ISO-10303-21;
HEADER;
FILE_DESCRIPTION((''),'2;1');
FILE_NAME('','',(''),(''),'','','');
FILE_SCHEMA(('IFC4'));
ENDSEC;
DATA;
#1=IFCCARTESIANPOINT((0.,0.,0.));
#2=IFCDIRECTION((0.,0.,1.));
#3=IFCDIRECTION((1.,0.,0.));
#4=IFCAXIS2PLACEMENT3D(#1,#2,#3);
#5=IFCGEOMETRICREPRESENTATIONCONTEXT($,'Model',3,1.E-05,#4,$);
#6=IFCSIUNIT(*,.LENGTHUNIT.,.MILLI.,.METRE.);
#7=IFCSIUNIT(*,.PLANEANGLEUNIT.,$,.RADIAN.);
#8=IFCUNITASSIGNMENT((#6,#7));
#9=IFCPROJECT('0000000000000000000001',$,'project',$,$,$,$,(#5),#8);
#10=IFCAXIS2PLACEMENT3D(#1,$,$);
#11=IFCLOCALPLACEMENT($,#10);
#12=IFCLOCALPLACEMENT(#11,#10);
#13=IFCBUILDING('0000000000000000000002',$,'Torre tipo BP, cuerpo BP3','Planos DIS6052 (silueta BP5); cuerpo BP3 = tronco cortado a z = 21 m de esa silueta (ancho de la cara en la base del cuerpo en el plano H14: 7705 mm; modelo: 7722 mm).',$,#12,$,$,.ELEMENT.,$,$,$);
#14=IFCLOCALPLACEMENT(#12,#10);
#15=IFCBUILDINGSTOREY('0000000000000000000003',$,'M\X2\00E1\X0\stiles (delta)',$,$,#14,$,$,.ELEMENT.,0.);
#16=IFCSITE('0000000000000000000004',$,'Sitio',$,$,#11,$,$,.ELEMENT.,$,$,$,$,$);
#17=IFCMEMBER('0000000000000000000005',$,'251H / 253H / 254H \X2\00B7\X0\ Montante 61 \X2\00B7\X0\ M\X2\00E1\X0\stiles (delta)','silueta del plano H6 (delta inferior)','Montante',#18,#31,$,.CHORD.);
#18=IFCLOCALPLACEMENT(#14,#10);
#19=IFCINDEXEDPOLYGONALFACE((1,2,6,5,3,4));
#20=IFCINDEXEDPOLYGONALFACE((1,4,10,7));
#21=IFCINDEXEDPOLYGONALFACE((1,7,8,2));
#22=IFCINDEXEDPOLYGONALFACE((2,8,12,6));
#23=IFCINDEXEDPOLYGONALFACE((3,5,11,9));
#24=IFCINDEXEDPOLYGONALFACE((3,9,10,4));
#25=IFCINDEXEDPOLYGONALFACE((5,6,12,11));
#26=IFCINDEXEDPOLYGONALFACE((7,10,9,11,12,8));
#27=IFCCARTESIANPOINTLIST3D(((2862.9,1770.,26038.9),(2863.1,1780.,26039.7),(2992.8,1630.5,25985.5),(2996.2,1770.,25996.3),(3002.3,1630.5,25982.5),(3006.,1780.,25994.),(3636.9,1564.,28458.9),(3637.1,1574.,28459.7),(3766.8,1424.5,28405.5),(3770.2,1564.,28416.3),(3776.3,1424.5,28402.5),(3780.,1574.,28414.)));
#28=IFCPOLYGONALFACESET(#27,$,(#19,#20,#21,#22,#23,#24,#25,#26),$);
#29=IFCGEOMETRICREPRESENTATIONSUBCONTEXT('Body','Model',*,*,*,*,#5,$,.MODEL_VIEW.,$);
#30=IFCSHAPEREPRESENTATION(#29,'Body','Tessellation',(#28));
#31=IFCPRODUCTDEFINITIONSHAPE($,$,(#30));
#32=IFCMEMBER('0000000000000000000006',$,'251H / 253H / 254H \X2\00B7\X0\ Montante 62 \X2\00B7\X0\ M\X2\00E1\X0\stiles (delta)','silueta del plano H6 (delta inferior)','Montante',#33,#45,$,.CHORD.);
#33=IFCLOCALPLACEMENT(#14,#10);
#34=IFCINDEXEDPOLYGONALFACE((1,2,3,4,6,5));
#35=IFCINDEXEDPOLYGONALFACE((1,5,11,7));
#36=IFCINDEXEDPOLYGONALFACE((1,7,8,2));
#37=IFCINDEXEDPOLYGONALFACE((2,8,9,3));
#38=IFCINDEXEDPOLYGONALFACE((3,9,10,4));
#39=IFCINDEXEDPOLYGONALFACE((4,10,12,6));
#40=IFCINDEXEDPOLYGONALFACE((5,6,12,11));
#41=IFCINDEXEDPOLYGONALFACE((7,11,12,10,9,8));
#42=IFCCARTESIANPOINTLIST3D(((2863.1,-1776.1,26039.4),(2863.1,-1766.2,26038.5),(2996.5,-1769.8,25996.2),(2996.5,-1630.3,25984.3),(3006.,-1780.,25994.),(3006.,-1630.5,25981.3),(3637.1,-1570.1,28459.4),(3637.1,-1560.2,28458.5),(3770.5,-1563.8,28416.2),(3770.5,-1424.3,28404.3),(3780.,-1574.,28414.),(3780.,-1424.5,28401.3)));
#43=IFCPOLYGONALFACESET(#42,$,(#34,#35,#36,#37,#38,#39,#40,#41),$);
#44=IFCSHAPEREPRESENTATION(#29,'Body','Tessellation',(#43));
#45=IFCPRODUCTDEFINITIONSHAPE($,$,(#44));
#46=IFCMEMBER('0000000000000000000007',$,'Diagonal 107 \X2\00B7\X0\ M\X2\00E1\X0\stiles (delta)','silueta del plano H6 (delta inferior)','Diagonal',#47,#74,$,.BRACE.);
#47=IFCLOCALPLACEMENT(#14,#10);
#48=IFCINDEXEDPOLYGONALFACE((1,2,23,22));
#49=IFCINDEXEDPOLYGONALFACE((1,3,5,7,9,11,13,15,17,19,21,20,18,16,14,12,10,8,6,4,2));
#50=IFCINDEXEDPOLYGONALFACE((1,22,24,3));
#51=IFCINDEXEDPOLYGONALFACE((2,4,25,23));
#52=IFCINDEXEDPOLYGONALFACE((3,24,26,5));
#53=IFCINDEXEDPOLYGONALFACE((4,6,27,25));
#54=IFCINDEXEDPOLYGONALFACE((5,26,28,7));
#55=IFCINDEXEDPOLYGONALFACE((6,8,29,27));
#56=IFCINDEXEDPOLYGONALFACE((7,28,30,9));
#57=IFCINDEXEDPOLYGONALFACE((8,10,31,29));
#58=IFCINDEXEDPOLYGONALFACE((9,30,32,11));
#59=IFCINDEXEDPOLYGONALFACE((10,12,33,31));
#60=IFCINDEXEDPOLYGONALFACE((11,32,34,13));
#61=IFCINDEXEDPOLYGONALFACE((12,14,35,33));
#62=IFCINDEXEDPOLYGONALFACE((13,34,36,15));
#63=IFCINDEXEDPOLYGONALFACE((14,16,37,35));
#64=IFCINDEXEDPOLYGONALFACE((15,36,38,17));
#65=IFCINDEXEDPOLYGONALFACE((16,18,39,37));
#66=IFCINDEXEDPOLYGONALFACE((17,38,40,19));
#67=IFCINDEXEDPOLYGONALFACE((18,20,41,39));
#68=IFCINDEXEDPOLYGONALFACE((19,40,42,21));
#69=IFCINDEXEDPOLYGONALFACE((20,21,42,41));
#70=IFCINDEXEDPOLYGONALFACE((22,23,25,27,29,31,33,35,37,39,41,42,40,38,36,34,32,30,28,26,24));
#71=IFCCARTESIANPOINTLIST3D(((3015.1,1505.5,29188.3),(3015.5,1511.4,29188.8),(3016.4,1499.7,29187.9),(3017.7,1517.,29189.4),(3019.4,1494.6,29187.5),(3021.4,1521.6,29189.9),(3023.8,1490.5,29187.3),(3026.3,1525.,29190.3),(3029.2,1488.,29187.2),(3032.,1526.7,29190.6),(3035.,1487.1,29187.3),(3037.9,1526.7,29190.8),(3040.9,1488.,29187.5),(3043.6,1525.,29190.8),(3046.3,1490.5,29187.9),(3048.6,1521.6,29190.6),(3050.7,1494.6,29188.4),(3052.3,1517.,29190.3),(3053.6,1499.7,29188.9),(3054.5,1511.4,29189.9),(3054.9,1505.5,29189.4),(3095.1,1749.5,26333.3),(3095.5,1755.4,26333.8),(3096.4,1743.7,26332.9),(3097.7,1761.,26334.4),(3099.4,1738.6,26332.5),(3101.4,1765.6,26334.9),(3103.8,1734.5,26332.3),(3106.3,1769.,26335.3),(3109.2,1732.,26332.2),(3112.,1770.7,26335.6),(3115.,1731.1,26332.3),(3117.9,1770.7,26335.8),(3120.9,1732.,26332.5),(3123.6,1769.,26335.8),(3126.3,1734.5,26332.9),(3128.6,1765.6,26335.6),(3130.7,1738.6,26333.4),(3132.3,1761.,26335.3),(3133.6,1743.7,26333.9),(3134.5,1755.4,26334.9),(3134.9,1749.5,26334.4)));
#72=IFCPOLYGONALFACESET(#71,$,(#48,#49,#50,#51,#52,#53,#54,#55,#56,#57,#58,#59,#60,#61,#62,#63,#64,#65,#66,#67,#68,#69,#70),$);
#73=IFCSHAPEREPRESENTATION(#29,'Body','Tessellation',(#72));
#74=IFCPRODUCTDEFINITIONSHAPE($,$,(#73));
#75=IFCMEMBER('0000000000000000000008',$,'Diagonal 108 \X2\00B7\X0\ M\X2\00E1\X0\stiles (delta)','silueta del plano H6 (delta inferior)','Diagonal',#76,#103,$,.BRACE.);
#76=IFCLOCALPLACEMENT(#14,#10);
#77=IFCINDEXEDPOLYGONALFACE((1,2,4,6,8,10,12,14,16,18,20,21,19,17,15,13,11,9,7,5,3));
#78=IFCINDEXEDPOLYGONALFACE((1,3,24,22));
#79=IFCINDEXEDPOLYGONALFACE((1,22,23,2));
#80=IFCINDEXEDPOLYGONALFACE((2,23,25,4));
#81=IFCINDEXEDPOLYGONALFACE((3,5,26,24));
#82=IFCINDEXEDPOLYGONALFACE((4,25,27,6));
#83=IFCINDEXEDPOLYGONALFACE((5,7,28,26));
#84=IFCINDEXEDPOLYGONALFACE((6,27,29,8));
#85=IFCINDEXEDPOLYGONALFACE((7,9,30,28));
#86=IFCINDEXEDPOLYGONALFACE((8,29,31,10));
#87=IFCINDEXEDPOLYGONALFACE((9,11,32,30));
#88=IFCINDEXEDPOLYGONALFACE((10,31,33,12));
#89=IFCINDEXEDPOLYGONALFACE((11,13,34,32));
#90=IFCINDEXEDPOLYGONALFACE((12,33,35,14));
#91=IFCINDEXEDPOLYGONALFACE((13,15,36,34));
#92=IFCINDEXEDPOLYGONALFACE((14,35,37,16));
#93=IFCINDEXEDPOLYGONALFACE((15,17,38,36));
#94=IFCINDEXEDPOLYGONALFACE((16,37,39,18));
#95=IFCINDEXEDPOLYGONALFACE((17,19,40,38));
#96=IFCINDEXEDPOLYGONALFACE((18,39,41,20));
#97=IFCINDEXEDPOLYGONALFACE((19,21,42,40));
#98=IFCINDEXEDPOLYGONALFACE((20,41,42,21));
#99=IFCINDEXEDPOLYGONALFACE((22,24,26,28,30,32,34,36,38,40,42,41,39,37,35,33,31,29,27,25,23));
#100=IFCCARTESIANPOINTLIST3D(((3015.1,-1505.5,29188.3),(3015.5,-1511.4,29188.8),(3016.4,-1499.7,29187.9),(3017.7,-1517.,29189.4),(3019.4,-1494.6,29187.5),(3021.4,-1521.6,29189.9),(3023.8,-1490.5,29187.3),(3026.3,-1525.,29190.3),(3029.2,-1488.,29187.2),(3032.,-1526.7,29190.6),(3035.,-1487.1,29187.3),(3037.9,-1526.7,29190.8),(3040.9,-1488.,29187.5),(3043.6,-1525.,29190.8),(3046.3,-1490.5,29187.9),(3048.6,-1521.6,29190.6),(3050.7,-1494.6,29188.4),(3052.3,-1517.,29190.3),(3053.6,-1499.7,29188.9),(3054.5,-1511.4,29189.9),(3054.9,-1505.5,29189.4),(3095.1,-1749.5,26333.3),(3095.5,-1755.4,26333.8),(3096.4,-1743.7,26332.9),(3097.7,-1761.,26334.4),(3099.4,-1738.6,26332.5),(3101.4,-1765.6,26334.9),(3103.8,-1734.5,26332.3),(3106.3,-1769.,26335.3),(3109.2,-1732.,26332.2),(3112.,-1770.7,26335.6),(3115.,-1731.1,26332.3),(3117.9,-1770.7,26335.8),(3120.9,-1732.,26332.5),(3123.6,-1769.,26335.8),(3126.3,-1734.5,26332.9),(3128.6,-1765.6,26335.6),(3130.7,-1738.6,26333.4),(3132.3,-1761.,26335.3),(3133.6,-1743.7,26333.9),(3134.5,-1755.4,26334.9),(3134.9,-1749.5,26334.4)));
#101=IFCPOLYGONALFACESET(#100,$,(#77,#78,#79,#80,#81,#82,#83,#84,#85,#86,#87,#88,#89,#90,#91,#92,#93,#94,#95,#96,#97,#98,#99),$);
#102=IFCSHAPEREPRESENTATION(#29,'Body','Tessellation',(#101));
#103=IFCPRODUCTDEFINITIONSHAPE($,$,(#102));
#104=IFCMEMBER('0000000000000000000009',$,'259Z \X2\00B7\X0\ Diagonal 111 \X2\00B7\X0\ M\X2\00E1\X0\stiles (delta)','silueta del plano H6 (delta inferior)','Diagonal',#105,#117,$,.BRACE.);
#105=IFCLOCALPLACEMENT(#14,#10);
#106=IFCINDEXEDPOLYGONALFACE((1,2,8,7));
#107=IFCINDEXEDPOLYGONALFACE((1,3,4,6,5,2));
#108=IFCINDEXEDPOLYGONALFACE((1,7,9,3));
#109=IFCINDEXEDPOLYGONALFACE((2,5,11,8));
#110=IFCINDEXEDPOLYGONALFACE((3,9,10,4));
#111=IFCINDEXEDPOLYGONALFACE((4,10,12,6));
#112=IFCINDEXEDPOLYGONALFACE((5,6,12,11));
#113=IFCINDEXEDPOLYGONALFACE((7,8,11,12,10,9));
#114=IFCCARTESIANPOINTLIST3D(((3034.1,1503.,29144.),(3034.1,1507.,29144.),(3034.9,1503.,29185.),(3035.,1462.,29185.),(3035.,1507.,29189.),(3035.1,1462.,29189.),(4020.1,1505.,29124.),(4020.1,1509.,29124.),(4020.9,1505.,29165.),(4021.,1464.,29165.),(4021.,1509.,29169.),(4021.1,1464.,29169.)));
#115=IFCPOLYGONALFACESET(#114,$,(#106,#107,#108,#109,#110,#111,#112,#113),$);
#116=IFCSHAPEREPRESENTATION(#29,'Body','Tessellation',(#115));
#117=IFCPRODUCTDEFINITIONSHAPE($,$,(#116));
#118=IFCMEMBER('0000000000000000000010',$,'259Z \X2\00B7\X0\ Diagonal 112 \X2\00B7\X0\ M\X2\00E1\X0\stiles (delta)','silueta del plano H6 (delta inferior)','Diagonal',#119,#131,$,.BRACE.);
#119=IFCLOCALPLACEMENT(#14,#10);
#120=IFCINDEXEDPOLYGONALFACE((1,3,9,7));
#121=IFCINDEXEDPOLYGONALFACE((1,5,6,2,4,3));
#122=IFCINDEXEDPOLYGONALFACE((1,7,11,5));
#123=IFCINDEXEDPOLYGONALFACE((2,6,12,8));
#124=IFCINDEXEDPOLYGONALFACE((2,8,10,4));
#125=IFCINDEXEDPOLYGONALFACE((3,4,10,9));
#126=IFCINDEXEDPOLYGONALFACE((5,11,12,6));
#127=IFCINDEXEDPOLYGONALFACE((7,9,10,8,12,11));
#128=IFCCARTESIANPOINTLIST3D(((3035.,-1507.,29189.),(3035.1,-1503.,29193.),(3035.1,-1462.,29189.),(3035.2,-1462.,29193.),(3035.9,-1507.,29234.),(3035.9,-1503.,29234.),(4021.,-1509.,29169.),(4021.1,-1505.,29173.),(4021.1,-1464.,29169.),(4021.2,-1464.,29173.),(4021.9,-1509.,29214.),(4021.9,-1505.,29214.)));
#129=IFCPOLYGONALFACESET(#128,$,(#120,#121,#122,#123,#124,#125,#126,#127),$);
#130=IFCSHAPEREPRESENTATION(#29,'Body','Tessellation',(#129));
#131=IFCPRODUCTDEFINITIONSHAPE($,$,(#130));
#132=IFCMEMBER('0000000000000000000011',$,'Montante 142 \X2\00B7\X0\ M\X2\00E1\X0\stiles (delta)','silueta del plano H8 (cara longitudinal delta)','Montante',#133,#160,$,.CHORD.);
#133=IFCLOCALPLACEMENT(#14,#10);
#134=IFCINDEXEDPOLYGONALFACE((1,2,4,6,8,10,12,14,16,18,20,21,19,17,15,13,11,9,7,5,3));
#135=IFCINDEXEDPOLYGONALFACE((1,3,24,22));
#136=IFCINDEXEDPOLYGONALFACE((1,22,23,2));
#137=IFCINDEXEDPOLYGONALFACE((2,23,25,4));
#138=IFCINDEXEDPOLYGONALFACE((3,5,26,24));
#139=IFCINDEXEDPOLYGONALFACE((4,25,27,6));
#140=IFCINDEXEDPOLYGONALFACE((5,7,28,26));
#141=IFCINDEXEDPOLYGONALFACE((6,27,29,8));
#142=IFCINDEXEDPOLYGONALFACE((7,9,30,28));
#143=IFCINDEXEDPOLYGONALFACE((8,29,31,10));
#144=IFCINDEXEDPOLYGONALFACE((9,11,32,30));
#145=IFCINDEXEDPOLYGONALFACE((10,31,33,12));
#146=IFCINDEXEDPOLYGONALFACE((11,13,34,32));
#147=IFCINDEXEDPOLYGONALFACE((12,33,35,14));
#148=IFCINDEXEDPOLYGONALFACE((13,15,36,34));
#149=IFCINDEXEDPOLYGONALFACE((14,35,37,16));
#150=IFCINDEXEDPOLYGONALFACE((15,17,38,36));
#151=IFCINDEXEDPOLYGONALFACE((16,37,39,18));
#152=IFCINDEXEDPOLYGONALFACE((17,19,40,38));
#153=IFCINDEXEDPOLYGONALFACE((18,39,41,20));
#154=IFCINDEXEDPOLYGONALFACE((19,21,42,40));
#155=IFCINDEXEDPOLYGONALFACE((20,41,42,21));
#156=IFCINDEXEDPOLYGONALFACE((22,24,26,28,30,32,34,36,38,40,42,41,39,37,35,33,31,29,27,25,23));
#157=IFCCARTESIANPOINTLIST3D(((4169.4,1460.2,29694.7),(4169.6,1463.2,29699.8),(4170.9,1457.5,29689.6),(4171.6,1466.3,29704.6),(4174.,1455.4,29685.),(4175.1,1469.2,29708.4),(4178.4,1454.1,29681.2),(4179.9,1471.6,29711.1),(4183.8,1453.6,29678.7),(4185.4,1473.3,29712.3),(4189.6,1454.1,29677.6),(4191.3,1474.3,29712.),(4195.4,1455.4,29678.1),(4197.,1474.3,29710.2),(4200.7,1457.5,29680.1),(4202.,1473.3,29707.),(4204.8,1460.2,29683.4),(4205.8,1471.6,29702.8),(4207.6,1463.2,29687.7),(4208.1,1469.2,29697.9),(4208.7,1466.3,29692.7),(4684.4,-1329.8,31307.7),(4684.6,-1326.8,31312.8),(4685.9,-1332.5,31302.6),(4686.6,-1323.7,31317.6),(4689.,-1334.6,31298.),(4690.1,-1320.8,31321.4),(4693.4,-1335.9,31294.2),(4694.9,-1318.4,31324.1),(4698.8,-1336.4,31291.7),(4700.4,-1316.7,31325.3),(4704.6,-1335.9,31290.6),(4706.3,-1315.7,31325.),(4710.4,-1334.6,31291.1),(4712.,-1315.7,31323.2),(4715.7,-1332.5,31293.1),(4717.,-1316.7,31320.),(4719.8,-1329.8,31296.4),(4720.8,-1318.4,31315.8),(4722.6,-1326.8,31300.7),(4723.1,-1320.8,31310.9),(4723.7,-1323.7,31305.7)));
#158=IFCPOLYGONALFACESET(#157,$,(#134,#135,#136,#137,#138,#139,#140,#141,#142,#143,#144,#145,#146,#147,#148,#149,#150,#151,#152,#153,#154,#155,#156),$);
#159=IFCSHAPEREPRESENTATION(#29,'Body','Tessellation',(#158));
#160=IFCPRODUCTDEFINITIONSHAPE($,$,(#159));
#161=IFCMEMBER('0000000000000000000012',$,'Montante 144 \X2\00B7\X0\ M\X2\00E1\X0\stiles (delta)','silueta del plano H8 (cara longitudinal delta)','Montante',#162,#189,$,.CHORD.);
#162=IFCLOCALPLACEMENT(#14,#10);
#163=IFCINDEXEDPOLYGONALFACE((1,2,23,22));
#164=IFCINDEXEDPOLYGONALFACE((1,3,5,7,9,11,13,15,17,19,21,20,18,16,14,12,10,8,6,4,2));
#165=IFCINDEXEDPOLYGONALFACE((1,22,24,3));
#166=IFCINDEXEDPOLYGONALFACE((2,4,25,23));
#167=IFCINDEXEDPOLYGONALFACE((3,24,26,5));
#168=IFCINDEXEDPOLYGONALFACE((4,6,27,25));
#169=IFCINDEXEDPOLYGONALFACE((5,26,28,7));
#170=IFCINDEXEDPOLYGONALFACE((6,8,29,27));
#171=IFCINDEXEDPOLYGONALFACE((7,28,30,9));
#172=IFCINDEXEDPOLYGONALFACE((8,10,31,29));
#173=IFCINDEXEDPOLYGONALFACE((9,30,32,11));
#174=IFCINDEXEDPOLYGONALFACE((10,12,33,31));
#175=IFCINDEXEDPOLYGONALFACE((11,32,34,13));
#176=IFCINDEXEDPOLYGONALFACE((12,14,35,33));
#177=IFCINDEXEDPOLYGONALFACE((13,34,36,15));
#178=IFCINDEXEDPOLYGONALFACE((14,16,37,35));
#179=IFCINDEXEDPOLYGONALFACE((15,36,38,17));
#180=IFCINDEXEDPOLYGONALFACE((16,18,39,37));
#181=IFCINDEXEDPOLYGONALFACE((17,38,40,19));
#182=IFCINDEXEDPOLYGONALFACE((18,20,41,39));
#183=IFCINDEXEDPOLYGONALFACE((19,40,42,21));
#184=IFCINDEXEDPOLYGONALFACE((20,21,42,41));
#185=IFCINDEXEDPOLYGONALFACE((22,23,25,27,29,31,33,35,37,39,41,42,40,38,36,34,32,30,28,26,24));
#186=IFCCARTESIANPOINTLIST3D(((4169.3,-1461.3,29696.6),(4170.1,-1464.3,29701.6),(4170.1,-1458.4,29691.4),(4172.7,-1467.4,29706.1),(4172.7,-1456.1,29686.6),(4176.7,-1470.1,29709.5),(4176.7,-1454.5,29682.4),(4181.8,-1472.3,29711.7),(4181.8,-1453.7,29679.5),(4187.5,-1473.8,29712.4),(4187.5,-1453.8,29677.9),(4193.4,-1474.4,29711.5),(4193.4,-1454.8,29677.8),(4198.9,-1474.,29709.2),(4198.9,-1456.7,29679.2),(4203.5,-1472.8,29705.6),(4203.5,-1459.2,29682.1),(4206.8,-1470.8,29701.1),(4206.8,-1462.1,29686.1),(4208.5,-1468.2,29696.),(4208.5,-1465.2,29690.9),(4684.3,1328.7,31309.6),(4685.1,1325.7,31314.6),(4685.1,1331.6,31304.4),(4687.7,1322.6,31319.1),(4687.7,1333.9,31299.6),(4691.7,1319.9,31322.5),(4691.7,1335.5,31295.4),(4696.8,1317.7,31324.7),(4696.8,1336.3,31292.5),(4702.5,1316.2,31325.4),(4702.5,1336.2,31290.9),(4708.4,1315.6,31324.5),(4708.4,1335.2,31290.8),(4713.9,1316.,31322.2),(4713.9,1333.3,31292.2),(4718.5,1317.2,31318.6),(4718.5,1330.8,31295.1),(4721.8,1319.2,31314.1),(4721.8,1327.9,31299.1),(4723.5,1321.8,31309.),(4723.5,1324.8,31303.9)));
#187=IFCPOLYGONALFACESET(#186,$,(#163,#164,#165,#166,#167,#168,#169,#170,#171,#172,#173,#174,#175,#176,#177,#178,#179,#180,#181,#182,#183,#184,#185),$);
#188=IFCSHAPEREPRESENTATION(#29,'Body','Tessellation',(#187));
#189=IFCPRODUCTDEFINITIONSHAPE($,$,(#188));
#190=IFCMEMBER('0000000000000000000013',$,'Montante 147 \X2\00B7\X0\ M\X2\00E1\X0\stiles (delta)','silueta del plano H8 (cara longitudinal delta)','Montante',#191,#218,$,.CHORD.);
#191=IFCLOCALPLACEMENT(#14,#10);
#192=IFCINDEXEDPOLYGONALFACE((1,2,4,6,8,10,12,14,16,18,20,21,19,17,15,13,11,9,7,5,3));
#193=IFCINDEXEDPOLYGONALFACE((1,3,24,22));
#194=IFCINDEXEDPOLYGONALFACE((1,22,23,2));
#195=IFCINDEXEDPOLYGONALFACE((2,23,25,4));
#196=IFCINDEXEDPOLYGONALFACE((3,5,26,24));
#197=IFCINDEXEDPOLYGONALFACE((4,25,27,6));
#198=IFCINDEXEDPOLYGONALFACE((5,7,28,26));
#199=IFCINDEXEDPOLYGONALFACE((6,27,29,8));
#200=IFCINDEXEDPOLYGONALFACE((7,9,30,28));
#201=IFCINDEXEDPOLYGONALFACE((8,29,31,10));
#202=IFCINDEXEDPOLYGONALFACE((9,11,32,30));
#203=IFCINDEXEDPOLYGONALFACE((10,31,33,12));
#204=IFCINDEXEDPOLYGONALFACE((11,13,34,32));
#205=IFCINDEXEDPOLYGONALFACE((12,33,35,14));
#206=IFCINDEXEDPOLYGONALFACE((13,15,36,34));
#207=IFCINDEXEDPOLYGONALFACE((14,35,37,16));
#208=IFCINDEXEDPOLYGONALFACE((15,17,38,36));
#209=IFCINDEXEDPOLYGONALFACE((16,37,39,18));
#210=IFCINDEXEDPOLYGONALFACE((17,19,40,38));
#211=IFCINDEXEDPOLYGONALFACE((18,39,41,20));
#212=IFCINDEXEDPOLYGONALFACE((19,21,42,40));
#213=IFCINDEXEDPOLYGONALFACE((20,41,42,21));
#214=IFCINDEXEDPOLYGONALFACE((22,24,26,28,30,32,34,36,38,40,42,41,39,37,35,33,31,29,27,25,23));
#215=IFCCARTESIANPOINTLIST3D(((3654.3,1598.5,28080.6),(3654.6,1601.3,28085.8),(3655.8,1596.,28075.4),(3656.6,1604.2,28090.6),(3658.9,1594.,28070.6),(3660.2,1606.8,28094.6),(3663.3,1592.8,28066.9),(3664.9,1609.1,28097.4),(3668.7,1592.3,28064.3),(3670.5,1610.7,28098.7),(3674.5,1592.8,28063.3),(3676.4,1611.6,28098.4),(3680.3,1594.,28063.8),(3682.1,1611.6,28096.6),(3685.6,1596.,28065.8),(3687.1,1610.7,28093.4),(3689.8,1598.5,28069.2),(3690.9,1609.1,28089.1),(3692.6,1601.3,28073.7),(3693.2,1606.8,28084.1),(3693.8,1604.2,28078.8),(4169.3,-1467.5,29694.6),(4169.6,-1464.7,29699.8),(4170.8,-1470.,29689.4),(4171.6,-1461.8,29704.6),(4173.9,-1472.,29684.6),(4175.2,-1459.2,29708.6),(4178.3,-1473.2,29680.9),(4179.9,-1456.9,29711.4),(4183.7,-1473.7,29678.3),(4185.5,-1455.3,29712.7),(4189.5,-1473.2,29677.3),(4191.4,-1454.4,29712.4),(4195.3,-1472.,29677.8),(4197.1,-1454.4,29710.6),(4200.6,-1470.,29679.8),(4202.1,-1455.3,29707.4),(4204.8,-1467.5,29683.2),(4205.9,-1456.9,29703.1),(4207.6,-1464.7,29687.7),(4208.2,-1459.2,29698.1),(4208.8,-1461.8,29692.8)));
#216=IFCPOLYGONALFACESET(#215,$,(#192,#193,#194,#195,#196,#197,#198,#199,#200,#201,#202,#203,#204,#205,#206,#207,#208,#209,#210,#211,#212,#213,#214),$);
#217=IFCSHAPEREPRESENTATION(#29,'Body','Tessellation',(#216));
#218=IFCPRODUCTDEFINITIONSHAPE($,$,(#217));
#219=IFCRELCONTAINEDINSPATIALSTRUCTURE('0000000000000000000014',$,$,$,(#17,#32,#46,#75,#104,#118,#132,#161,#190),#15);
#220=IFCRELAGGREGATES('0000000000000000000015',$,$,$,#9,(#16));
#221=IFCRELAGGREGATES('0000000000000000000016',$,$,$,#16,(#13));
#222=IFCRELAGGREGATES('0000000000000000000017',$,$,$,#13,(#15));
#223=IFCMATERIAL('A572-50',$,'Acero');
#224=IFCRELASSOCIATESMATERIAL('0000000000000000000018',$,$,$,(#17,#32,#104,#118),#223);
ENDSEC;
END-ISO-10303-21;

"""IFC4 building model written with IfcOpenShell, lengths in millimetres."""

from ifc_helpers import new_model, si_unit, frame, frame_2d, origin, origin_with_axes, place, context, subcontext, project, spatial, circle, l_section, extrude, material, element, save


model = new_model("IFC4")

# Units and contexts
model_context = context("Model", 3, precision=1e-05, world=origin_with_axes())
body_context = subcontext(model_context, "Body", "Model", "MODEL_VIEW")
ifc_project = project(units=[si_unit("LENGTHUNIT", "METRE", prefix="MILLI"), si_unit("PLANEANGLEUNIT", "RADIAN")], contexts=[model_context])

# Site, building, storey
site_placement = place(None, origin())
site = spatial("IfcSite", under=ifc_project, at=site_placement, Name="Sitio", CompositionType="ELEMENT")
building_placement = place(site_placement, origin())
building = spatial("IfcBuilding", under=site, at=building_placement, Name="Torre tipo BP, cuerpo BP3", Description="Planos DIS6052 (silueta BP5); cuerpo BP3 = tronco cortado a z = 21 m de esa silueta (ancho de la cara en la base del cuerpo en el plano H14: 7705 mm; modelo: 7722 mm).", CompositionType="ELEMENT")
storey_placement = place(building_placement, origin())
storey = spatial("IfcBuildingStorey", under=building, at=storey_placement, Name="Mástiles (delta)", CompositionType="ELEMENT", Elevation=0.0)

# Members
ifc_material = material(Name="A572-50", Category="Acero")
for number, where, z_axis, x_axis, name in (
    (1, (3780.0, 1574.0, 28414.0), (-0.303637, 0.080813, -0.949355), (-0.024618, -0.996729, -0.076972), "251H / 253H / 254H · Montante 61 · Mástiles (delta)"),
    (2, (3780.0, -1574.0, 28414.0), (-0.303637, -0.080813, -0.949355), (-0.952788, 0.025754, 0.302542), "251H / 253H / 254H · Montante 62 · Mástiles (delta)"),
):
    element("IfcMember", number, at=place(storey_placement, frame(where, z_axis=z_axis, x_axis=x_axis)), inside=storey, material=ifc_material, Name=name, Description="silueta del plano H6 (delta inferior)", ObjectType="Montante", PredefinedType="CHORD", context=body_context, shape_type="SweptSolid", body=[
        extrude(l_section(Depth=150.0, Width=150.0, Thickness=10.0, at=frame_2d((75.0, 75.0))), None, (0.0, 0.0, 1.0), 2549.1),
    ])
for number, where, z_axis, x_axis, name in (
    (3, (3035.0, 1507.0, 29189.0), (0.027908, 0.085121, -0.99598), (0.002384, -0.996371, -0.085087), "Diagonal 107 · Mástiles (delta)"),
    (4, (3035.0, -1507.0, 29189.0), (0.027908, -0.085121, -0.99598), (0.002384, 0.996371, -0.085087), "Diagonal 108 · Mástiles (delta)"),
):
    element("IfcMember", number, at=place(storey_placement, frame(where, z_axis=z_axis, x_axis=x_axis)), inside=storey, Name=name, Description="silueta del plano H6 (delta inferior)", ObjectType="Diagonal", PredefinedType="BRACE", context=body_context, shape_type="SweptSolid", body=[
        extrude(circle(Radius=20.0), None, (0.0, 0.0, 1.0), 2866.5),
    ])
for number, where, z_axis, x_axis, name in (
    (5, (3035.0, 1507.0, 29189.0), (0.999792, 0.002028, -0.02028), (0.002028, -0.999998, -0.000041), "259Z · Diagonal 111 · Mástiles (delta)"),
    (6, (3035.0, -1507.0, 29189.0), (0.999792, -0.002028, -0.02028), (0.002028, 0.999998, -0.000041), "259Z · Diagonal 112 · Mástiles (delta)"),
):
    element("IfcMember", number, at=place(storey_placement, frame(where, z_axis=z_axis, x_axis=x_axis)), inside=storey, material=ifc_material, Name=name, Description="silueta del plano H6 (delta inferior)", ObjectType="Diagonal", PredefinedType="BRACE", context=body_context, shape_type="SweptSolid", body=[
        extrude(l_section(Depth=45.0, Width=45.0, Thickness=4.0, at=frame_2d((22.5, 22.5))), None, (0.0, 0.0, 1.0), 986.2),
    ])
for number, where, z_axis, x_axis, name in (
    (7, (4704.0, -1326.0, 31308.0), (-0.157801, 0.854884, -0.494239), (-0.260017, -0.518819, -0.814382), "Montante 142 · Mástiles (delta)"),
    (8, (4704.0, 1326.0, 31308.0), (-0.157801, -0.854884, -0.494239), (-0.987471, 0.136613, 0.078981), "Montante 144 · Mástiles (delta)"),
):
    element("IfcMember", number, at=place(storey_placement, frame(where, z_axis=z_axis, x_axis=x_axis)), inside=storey, Name=name, Description="silueta del plano H8 (cara longitudinal delta)", ObjectType="Montante", PredefinedType="CHORD", context=body_context, shape_type="SweptSolid", body=[
        extrude(circle(Radius=20.0), None, (0.0, 0.0, 1.0), 3263.6),
    ])
member_1_placement = place(storey_placement, frame((4189.0, -1464.0, 29695.0), z_axis=(-0.147019, 0.875265, -0.460756), x_axis=(-0.266066, -0.483643, -0.833845)))
element("IfcMember", 9, at=member_1_placement, inside=storey, Name="Montante 147 · Mástiles (delta)", Description="silueta del plano H8 (cara longitudinal delta)", ObjectType="Montante", PredefinedType="CHORD", context=body_context, shape_type="SweptSolid", body=[
    extrude(circle(Radius=20.0), None, (0.0, 0.0, 1.0), 3502.9),
])

save(model, "model.ifc")
